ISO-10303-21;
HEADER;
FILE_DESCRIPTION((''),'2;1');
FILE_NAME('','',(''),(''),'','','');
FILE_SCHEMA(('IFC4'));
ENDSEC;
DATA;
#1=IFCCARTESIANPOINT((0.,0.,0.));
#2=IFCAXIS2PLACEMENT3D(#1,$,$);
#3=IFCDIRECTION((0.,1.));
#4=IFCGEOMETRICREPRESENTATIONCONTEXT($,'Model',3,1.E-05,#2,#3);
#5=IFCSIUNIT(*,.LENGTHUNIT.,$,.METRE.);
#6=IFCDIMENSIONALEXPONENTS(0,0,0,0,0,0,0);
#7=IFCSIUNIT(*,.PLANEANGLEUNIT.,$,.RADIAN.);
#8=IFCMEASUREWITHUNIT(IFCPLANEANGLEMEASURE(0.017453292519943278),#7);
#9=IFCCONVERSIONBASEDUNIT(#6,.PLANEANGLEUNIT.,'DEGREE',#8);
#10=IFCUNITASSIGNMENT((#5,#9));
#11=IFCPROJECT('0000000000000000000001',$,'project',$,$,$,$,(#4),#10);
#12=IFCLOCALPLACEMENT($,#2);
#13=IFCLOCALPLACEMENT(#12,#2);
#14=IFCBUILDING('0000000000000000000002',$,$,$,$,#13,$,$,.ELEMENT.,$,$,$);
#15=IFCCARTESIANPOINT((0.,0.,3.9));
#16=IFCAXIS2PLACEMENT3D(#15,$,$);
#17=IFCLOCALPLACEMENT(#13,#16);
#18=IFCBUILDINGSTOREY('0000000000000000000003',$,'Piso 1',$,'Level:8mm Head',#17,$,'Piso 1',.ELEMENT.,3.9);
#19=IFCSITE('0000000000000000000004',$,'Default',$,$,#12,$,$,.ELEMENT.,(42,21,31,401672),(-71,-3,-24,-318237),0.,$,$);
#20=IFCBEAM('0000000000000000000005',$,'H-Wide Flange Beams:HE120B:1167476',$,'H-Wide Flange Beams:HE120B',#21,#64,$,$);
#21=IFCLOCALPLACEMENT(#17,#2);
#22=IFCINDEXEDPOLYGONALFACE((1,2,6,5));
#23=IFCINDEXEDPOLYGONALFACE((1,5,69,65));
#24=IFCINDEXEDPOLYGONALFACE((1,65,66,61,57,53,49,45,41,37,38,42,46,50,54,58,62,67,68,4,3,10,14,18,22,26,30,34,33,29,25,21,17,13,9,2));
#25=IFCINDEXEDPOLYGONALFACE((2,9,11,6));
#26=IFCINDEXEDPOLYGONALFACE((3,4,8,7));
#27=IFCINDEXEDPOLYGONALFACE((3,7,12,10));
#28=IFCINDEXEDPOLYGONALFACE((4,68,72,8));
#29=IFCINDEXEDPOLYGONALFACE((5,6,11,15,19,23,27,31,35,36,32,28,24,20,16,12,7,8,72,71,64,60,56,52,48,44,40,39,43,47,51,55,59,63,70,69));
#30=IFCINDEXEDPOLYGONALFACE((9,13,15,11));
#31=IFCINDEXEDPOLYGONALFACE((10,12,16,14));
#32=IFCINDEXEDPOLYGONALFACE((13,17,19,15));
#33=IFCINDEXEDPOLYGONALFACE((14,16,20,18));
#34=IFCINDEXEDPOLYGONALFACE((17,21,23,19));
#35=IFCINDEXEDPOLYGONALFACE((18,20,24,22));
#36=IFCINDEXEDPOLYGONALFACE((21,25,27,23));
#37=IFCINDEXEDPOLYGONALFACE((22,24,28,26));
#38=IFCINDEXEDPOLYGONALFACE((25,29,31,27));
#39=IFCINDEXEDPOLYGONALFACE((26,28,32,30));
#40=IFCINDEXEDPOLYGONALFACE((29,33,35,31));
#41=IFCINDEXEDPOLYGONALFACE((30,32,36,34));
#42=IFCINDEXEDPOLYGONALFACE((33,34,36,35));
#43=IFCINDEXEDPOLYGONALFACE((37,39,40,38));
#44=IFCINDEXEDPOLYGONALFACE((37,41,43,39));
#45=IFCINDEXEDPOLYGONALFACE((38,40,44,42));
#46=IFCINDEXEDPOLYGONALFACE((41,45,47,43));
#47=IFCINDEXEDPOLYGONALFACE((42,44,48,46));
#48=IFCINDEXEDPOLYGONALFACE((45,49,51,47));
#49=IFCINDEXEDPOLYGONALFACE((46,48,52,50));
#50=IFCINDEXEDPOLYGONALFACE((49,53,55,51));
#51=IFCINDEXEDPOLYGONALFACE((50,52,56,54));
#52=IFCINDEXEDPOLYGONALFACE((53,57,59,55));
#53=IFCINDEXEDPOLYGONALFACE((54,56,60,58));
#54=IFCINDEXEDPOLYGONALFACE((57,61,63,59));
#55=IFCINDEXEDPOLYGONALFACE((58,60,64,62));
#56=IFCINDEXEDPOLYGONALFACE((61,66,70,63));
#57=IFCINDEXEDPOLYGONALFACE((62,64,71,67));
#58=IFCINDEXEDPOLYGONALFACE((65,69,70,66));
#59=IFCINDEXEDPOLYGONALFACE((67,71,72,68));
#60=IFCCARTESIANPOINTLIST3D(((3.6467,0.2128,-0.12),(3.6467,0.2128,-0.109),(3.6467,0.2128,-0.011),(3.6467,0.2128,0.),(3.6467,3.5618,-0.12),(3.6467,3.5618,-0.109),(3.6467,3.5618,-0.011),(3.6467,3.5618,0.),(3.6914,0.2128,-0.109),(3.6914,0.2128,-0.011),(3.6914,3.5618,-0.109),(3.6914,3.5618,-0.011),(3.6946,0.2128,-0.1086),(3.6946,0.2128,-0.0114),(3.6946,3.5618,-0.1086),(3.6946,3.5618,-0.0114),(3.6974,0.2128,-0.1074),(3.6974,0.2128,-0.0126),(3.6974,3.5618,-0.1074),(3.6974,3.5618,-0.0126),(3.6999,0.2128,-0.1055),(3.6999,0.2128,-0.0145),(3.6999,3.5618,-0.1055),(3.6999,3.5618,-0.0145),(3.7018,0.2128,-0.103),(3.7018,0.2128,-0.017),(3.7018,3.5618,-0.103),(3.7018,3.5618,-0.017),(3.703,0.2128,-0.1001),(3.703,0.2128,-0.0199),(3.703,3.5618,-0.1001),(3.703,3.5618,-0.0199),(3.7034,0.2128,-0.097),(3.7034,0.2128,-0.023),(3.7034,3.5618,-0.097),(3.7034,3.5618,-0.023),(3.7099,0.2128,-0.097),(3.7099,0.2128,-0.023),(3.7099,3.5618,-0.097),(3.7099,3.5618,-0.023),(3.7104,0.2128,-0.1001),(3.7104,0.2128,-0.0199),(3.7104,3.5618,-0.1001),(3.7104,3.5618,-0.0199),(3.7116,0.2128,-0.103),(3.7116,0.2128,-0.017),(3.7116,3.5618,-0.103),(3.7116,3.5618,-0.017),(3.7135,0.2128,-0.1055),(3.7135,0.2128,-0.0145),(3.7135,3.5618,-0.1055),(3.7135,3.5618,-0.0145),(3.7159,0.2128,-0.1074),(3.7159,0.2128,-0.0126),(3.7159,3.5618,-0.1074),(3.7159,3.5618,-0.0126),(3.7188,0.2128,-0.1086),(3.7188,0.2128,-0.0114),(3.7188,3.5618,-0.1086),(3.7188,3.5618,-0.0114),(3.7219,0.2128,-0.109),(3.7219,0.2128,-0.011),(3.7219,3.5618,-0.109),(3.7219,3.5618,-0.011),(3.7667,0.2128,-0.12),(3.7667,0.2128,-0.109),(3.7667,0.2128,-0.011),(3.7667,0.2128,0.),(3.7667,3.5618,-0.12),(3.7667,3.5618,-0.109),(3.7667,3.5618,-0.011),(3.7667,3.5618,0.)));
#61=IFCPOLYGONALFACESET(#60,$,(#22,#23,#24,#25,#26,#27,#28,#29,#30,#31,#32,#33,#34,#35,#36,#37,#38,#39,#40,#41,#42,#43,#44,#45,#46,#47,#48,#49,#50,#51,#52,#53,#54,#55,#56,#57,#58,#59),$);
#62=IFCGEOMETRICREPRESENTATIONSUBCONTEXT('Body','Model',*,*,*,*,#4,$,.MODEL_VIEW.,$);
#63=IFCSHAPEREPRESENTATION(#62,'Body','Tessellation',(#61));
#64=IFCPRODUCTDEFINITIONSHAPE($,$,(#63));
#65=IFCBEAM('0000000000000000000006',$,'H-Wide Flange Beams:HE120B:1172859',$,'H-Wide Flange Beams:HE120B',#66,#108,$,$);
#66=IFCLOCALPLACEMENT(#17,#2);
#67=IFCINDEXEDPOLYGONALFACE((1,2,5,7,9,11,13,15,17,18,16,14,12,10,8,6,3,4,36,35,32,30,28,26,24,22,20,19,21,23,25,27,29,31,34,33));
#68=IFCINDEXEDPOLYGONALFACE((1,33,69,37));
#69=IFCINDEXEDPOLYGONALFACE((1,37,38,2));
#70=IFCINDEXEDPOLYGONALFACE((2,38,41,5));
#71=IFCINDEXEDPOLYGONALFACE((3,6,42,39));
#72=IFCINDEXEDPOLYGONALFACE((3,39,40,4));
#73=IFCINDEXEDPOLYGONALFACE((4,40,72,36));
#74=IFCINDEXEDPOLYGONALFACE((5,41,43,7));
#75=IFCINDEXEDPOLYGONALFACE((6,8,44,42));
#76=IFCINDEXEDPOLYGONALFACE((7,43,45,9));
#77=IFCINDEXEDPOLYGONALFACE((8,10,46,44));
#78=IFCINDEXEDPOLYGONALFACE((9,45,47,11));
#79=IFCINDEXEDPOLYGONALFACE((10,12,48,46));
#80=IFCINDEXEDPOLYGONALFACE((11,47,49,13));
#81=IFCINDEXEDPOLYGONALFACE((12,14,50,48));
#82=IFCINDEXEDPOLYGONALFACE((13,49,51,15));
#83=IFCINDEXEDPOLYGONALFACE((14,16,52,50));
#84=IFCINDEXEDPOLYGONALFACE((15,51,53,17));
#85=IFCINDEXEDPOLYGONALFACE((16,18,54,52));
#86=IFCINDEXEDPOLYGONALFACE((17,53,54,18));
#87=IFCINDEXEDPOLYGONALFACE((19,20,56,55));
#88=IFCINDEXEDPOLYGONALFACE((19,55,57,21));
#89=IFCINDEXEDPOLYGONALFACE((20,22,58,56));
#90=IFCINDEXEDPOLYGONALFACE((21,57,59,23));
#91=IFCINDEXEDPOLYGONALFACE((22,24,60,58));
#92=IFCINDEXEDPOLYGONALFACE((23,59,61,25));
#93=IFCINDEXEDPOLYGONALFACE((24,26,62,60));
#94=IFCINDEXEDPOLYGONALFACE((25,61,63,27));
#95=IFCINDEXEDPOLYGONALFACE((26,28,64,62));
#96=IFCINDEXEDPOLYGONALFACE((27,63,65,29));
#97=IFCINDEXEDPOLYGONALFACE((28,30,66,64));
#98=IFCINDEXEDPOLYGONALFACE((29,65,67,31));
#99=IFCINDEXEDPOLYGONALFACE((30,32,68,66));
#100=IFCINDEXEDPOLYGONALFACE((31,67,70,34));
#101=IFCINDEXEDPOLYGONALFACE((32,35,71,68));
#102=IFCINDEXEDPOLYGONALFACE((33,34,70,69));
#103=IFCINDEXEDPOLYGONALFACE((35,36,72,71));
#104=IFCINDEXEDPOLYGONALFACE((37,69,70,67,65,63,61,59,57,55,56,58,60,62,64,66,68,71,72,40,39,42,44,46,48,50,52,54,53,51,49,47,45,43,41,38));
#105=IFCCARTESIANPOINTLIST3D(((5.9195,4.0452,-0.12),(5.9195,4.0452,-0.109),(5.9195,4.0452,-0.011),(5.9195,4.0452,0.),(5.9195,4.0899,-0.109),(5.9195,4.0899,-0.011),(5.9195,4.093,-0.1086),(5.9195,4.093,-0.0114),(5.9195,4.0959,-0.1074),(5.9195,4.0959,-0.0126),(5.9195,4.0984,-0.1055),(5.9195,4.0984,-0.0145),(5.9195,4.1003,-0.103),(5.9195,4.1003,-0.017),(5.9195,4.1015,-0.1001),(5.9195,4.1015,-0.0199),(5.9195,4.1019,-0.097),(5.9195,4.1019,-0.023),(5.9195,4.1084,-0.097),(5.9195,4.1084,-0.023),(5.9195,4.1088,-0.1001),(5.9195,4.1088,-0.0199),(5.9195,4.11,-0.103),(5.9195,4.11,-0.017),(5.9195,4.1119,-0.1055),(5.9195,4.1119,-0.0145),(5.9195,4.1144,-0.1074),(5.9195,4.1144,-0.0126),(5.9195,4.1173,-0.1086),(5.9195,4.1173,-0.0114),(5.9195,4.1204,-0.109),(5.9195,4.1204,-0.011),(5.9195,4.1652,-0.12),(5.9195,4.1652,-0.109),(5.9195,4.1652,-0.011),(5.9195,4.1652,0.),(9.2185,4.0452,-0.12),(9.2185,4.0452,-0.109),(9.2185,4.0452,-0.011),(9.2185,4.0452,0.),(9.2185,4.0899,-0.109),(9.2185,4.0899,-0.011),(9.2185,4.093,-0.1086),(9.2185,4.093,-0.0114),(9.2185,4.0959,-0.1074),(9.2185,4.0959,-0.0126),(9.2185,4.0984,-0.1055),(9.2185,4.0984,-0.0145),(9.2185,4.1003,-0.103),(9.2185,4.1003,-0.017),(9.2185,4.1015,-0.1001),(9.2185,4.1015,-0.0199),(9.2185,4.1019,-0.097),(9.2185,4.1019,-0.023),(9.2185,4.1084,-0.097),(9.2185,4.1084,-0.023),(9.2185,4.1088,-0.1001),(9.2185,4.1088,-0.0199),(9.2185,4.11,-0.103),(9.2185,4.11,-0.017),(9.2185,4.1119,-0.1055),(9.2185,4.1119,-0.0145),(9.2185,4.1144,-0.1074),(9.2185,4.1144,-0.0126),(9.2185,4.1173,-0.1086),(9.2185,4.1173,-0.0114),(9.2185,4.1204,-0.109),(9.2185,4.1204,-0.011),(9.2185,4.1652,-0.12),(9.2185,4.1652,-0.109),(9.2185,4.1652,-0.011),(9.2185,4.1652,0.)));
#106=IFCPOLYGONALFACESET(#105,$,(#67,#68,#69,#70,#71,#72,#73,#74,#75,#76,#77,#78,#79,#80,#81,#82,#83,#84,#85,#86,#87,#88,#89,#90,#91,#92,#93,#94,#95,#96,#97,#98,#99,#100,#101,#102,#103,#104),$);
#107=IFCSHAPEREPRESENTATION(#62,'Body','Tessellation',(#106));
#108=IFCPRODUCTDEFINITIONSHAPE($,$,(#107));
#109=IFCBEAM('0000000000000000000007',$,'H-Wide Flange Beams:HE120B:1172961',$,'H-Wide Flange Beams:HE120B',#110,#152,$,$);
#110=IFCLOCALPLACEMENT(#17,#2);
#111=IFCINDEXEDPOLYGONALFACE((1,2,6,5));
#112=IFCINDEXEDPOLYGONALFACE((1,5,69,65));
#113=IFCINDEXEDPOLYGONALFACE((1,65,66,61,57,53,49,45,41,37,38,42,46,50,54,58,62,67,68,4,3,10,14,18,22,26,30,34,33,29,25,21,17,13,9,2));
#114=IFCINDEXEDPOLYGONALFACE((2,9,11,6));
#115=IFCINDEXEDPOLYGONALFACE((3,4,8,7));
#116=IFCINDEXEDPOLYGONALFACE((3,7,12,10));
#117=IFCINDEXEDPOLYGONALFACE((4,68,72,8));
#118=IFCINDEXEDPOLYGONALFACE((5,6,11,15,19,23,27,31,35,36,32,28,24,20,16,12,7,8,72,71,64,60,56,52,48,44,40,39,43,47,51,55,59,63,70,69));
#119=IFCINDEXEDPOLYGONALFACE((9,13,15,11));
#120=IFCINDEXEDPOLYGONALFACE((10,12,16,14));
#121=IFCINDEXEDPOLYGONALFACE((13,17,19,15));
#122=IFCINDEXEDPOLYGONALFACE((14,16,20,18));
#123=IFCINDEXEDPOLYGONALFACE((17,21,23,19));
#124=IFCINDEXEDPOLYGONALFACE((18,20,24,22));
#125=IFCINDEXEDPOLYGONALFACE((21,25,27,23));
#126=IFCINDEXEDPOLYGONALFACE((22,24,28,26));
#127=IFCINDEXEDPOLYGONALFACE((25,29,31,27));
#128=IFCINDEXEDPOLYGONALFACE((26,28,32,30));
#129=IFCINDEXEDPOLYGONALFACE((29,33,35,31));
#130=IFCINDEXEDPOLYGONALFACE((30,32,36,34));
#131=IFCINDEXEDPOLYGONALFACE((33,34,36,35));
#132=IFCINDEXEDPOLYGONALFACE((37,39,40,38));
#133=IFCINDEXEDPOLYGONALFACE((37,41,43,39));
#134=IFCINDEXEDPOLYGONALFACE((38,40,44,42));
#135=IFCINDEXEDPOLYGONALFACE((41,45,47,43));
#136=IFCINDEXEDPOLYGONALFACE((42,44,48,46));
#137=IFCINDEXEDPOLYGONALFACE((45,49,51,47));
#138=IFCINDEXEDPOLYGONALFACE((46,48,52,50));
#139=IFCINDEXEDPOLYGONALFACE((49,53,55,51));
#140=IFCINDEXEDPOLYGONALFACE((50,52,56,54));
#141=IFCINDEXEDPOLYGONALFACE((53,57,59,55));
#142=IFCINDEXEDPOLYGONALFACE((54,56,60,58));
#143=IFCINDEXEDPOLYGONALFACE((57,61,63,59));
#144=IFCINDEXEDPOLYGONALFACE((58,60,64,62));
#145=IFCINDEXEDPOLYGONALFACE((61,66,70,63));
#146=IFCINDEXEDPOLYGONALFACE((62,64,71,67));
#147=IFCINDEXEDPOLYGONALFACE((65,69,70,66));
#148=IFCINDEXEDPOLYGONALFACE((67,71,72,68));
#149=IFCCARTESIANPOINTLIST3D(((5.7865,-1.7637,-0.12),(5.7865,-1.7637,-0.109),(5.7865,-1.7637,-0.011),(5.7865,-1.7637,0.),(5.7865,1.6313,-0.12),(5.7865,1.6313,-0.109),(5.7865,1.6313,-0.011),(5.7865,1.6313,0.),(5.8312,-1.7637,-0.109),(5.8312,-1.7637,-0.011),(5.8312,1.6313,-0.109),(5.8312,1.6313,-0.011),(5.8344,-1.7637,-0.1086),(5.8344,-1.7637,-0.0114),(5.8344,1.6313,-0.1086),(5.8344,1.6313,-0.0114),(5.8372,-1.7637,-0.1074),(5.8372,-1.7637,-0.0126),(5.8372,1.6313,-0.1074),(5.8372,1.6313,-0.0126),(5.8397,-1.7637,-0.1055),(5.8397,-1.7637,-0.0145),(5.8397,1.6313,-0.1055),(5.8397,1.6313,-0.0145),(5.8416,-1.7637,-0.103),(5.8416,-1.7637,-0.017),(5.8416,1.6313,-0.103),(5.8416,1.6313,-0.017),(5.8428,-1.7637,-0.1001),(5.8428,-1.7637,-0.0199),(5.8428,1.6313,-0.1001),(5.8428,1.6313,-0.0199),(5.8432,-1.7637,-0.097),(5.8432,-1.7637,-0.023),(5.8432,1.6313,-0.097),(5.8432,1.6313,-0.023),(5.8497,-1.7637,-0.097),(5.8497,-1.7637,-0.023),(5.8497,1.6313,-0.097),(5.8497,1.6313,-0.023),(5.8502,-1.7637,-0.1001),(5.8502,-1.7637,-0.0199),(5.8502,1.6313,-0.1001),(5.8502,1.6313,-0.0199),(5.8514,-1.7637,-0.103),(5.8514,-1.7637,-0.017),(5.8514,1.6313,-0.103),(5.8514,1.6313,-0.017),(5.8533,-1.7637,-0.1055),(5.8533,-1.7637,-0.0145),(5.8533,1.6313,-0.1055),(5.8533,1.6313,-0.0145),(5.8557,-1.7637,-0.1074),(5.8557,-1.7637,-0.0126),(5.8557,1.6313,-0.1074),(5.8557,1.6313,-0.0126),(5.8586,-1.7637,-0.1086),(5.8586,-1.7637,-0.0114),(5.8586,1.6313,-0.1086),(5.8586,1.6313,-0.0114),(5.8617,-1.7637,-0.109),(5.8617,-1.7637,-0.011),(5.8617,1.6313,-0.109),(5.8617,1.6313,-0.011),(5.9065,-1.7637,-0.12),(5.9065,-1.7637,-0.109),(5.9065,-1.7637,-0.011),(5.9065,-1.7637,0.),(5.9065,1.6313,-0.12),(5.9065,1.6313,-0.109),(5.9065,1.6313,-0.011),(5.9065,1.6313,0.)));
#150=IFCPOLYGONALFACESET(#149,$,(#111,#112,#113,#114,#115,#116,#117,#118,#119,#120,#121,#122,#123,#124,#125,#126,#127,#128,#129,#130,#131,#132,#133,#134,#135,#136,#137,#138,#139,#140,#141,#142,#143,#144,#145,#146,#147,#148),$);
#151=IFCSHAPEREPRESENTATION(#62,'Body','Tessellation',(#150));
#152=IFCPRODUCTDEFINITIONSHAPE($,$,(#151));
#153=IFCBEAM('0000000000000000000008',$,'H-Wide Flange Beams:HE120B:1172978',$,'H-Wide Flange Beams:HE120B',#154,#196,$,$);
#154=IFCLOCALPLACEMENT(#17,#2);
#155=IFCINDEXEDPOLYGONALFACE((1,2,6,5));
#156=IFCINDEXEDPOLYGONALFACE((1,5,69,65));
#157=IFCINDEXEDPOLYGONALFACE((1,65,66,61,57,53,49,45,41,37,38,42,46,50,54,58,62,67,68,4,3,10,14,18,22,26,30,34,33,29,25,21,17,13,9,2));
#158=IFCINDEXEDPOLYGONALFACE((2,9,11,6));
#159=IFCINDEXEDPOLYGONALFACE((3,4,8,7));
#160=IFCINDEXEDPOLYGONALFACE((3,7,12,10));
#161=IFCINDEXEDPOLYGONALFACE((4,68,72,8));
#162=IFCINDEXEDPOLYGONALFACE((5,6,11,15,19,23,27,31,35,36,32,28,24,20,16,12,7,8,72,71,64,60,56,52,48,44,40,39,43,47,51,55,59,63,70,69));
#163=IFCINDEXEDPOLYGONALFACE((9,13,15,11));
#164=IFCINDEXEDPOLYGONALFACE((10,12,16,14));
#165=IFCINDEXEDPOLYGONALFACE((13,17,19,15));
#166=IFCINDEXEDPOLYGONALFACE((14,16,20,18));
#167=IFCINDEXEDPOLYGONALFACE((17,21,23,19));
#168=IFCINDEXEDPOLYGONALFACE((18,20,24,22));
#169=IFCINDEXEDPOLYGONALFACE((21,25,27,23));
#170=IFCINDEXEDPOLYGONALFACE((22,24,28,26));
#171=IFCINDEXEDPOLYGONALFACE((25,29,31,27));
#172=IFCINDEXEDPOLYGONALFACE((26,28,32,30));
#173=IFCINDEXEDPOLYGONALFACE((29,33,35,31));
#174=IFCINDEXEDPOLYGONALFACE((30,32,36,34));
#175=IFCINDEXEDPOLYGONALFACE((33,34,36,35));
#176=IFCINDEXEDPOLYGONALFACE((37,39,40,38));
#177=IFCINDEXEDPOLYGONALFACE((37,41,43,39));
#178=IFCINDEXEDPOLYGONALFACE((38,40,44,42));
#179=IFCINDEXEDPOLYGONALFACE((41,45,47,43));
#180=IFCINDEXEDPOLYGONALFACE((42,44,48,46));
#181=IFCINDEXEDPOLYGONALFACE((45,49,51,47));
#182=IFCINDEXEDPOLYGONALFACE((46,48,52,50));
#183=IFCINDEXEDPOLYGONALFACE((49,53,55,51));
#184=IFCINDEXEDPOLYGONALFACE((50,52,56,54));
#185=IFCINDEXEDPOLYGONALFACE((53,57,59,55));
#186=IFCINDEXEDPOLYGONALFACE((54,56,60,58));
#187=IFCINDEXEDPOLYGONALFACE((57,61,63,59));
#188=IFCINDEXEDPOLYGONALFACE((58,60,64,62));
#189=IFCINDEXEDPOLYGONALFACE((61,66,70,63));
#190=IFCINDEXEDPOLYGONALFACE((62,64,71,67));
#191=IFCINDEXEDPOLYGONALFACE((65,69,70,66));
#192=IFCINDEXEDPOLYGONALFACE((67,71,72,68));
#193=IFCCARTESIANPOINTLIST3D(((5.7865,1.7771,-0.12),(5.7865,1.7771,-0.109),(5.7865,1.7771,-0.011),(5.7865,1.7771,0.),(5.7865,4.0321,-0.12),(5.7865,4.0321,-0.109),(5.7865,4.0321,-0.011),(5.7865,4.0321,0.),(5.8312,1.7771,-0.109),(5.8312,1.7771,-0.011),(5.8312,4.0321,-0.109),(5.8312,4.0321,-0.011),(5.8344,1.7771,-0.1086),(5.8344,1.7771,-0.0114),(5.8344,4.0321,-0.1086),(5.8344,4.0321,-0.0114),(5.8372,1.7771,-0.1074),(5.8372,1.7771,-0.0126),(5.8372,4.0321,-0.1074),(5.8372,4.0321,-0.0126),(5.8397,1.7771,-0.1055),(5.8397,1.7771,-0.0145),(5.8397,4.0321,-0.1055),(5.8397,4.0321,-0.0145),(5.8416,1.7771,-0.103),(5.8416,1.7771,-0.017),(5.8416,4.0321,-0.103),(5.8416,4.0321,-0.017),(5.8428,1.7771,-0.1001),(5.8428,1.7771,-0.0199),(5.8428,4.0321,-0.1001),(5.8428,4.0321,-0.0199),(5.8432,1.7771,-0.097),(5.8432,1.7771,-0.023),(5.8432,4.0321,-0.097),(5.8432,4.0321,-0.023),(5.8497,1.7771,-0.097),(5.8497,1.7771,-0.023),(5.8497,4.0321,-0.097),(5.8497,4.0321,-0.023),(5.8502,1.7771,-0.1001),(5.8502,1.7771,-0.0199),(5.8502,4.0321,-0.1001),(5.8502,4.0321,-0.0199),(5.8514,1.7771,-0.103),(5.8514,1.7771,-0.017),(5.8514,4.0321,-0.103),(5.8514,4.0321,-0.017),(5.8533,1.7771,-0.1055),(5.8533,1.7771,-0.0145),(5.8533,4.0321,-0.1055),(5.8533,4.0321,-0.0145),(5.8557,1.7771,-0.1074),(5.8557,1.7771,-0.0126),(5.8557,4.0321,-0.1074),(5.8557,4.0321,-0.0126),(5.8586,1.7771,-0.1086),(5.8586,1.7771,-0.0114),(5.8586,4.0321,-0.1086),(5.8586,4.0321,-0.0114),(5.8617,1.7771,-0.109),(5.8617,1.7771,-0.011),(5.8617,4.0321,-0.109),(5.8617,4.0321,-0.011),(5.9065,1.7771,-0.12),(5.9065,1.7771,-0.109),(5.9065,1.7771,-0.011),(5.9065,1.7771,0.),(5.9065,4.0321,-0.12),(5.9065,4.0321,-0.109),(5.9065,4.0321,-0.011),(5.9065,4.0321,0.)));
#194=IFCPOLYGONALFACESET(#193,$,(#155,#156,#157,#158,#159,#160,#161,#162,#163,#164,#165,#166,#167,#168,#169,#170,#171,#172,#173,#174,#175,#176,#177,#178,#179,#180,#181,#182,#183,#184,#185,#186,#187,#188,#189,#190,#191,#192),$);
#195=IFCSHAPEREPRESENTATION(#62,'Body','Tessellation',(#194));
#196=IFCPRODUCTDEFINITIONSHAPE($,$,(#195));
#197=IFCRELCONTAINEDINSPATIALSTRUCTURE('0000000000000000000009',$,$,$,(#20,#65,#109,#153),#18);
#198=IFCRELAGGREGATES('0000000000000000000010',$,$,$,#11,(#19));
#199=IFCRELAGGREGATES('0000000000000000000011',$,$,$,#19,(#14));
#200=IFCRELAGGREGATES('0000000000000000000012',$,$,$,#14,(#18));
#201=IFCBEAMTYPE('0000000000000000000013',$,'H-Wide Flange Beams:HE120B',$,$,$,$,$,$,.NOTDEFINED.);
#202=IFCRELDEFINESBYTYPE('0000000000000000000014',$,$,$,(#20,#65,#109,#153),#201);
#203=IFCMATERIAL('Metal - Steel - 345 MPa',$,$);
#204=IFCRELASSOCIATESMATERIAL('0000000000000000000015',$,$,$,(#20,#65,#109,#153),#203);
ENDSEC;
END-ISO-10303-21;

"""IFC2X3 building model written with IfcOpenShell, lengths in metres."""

from ifc_helpers import new_model, entity, si_unit, converted_unit, direction, frame, frame_2d, origin, place, context, subcontext, project, spatial, i_section, extrude, material, type_object, element, save


model = new_model("IFC2X3")

# Units and contexts
model_context = context("Model", 3, precision=1e-05, world=origin(), true_north=direction((0.0, 1.0)))
body_context = subcontext(model_context, "Body", "Model", "MODEL_VIEW")
ifc_project = project(units=[si_unit("LENGTHUNIT", "METRE"), converted_unit("PLANEANGLEUNIT", "DEGREE", entity("IfcPlaneAngleMeasure", 0.017453292519943278), si_unit("PLANEANGLEUNIT", "RADIAN"), dimensions=[0, 0, 0, 0, 0, 0, 0])], contexts=[model_context])

# Site, building, storey
site_placement = place(None, origin())
site = spatial("IfcSite", under=ifc_project, at=site_placement, Name="Default", CompositionType="ELEMENT", RefLatitude=(42, 21, 31, 401672), RefLongitude=(-71, -3, -24, -318237), RefElevation=0.0)
building_placement = place(site_placement, origin())
building = spatial("IfcBuilding", under=site, at=building_placement, CompositionType="ELEMENT")
storey_placement = place(building_placement, frame((0.0, 0.0, 3.9)))
storey = spatial("IfcBuildingStorey", under=building, at=storey_placement, Name="Piso 1", ObjectType="Level:8mm Head", LongName="Piso 1", CompositionType="ELEMENT", Elevation=3.9)

# Beams
ifc_material_1 = material(Name="Metal - Steel - 345 MPa")
beam_type_1 = type_object("IfcBeamType", Name="H-Wide Flange Beams:HE120B", PredefinedType="NOTDEFINED")
beam_1_placement = place(storey_placement, frame((3.7067, 3.6349, 0.0), z_axis=(0.0, 0.0, 1.0), x_axis=(0.0, -1.0, 0.0)))
element("IfcBeam", 1, at=beam_1_placement, inside=storey, type_object=beam_type_1, material=ifc_material_1, Name="H-Wide Flange Beams:HE120B:1167476", ObjectType="H-Wide Flange Beams:HE120B", context=body_context, shape_type="SweptSolid", body=[
    extrude(i_section(OverallWidth=0.12, OverallDepth=0.12, WebThickness=0.0065, FlangeThickness=0.011, FilletRadius=0.012, at=frame_2d((0.0, 0.0), x_axis=(0.0, 1.0))), frame((0.073, 0.0, -0.06), z_axis=(1.0, 0.0, 0.0), x_axis=(0.0, 0.0, -1.0)), (0.0, 0.0, 1.0), 3.349),
])
beam_2_placement = place(storey_placement, frame((5.8465, 4.1052, 0.0)))
element("IfcBeam", 2, at=beam_2_placement, inside=storey, type_object=beam_type_1, material=ifc_material_1, Name="H-Wide Flange Beams:HE120B:1172859", ObjectType="H-Wide Flange Beams:HE120B", context=body_context, shape_type="SweptSolid", body=[
    extrude(i_section(OverallWidth=0.12, OverallDepth=0.12, WebThickness=0.0065, FlangeThickness=0.011, FilletRadius=0.012, at=frame_2d((0.0, 0.0), x_axis=(0.0, 1.0))), frame((0.073, 0.0, -0.06), z_axis=(1.0, 0.0, 0.0), x_axis=(0.0, 0.0, -1.0)), (0.0, 0.0, 1.0), 3.299),
])
beam_3_placement = place(storey_placement, frame((5.8465, -1.8365, 0.0), z_axis=(0.0, 0.0, 1.0), x_axis=(0.0, 1.0, 0.0)))
element("IfcBeam", 3, at=beam_3_placement, inside=storey, type_object=beam_type_1, material=ifc_material_1, Name="H-Wide Flange Beams:HE120B:1172961", ObjectType="H-Wide Flange Beams:HE120B", context=body_context, shape_type="SweptSolid", body=[
    extrude(i_section(OverallWidth=0.12, OverallDepth=0.12, WebThickness=0.0065, FlangeThickness=0.011, FilletRadius=0.012, at=frame_2d((0.0, 0.0), x_axis=(0.0, 1.0))), frame((0.0728, 0.0, -0.06), z_axis=(1.0, 0.0, 0.0), x_axis=(0.0, 0.0, -1.0)), (0.0, 0.0, 1.0), 3.395),
])
beam_4_placement = place(storey_placement, frame((5.8465, 1.7041, 0.0), z_axis=(0.0, 0.0, 1.0), x_axis=(0.0, 1.0, 0.0)))
element("IfcBeam", 4, at=beam_4_placement, inside=storey, type_object=beam_type_1, material=ifc_material_1, Name="H-Wide Flange Beams:HE120B:1172978", ObjectType="H-Wide Flange Beams:HE120B", context=body_context, shape_type="SweptSolid", body=[
    extrude(i_section(OverallWidth=0.12, OverallDepth=0.12, WebThickness=0.0065, FlangeThickness=0.011, FilletRadius=0.012, at=frame_2d((0.0, 0.0), x_axis=(0.0, 1.0))), frame((0.073, 0.0, -0.06), z_axis=(1.0, 0.0, 0.0), x_axis=(0.0, 0.0, -1.0)), (0.0, 0.0, 1.0), 2.255),
])

save(model, "model.ifc")
